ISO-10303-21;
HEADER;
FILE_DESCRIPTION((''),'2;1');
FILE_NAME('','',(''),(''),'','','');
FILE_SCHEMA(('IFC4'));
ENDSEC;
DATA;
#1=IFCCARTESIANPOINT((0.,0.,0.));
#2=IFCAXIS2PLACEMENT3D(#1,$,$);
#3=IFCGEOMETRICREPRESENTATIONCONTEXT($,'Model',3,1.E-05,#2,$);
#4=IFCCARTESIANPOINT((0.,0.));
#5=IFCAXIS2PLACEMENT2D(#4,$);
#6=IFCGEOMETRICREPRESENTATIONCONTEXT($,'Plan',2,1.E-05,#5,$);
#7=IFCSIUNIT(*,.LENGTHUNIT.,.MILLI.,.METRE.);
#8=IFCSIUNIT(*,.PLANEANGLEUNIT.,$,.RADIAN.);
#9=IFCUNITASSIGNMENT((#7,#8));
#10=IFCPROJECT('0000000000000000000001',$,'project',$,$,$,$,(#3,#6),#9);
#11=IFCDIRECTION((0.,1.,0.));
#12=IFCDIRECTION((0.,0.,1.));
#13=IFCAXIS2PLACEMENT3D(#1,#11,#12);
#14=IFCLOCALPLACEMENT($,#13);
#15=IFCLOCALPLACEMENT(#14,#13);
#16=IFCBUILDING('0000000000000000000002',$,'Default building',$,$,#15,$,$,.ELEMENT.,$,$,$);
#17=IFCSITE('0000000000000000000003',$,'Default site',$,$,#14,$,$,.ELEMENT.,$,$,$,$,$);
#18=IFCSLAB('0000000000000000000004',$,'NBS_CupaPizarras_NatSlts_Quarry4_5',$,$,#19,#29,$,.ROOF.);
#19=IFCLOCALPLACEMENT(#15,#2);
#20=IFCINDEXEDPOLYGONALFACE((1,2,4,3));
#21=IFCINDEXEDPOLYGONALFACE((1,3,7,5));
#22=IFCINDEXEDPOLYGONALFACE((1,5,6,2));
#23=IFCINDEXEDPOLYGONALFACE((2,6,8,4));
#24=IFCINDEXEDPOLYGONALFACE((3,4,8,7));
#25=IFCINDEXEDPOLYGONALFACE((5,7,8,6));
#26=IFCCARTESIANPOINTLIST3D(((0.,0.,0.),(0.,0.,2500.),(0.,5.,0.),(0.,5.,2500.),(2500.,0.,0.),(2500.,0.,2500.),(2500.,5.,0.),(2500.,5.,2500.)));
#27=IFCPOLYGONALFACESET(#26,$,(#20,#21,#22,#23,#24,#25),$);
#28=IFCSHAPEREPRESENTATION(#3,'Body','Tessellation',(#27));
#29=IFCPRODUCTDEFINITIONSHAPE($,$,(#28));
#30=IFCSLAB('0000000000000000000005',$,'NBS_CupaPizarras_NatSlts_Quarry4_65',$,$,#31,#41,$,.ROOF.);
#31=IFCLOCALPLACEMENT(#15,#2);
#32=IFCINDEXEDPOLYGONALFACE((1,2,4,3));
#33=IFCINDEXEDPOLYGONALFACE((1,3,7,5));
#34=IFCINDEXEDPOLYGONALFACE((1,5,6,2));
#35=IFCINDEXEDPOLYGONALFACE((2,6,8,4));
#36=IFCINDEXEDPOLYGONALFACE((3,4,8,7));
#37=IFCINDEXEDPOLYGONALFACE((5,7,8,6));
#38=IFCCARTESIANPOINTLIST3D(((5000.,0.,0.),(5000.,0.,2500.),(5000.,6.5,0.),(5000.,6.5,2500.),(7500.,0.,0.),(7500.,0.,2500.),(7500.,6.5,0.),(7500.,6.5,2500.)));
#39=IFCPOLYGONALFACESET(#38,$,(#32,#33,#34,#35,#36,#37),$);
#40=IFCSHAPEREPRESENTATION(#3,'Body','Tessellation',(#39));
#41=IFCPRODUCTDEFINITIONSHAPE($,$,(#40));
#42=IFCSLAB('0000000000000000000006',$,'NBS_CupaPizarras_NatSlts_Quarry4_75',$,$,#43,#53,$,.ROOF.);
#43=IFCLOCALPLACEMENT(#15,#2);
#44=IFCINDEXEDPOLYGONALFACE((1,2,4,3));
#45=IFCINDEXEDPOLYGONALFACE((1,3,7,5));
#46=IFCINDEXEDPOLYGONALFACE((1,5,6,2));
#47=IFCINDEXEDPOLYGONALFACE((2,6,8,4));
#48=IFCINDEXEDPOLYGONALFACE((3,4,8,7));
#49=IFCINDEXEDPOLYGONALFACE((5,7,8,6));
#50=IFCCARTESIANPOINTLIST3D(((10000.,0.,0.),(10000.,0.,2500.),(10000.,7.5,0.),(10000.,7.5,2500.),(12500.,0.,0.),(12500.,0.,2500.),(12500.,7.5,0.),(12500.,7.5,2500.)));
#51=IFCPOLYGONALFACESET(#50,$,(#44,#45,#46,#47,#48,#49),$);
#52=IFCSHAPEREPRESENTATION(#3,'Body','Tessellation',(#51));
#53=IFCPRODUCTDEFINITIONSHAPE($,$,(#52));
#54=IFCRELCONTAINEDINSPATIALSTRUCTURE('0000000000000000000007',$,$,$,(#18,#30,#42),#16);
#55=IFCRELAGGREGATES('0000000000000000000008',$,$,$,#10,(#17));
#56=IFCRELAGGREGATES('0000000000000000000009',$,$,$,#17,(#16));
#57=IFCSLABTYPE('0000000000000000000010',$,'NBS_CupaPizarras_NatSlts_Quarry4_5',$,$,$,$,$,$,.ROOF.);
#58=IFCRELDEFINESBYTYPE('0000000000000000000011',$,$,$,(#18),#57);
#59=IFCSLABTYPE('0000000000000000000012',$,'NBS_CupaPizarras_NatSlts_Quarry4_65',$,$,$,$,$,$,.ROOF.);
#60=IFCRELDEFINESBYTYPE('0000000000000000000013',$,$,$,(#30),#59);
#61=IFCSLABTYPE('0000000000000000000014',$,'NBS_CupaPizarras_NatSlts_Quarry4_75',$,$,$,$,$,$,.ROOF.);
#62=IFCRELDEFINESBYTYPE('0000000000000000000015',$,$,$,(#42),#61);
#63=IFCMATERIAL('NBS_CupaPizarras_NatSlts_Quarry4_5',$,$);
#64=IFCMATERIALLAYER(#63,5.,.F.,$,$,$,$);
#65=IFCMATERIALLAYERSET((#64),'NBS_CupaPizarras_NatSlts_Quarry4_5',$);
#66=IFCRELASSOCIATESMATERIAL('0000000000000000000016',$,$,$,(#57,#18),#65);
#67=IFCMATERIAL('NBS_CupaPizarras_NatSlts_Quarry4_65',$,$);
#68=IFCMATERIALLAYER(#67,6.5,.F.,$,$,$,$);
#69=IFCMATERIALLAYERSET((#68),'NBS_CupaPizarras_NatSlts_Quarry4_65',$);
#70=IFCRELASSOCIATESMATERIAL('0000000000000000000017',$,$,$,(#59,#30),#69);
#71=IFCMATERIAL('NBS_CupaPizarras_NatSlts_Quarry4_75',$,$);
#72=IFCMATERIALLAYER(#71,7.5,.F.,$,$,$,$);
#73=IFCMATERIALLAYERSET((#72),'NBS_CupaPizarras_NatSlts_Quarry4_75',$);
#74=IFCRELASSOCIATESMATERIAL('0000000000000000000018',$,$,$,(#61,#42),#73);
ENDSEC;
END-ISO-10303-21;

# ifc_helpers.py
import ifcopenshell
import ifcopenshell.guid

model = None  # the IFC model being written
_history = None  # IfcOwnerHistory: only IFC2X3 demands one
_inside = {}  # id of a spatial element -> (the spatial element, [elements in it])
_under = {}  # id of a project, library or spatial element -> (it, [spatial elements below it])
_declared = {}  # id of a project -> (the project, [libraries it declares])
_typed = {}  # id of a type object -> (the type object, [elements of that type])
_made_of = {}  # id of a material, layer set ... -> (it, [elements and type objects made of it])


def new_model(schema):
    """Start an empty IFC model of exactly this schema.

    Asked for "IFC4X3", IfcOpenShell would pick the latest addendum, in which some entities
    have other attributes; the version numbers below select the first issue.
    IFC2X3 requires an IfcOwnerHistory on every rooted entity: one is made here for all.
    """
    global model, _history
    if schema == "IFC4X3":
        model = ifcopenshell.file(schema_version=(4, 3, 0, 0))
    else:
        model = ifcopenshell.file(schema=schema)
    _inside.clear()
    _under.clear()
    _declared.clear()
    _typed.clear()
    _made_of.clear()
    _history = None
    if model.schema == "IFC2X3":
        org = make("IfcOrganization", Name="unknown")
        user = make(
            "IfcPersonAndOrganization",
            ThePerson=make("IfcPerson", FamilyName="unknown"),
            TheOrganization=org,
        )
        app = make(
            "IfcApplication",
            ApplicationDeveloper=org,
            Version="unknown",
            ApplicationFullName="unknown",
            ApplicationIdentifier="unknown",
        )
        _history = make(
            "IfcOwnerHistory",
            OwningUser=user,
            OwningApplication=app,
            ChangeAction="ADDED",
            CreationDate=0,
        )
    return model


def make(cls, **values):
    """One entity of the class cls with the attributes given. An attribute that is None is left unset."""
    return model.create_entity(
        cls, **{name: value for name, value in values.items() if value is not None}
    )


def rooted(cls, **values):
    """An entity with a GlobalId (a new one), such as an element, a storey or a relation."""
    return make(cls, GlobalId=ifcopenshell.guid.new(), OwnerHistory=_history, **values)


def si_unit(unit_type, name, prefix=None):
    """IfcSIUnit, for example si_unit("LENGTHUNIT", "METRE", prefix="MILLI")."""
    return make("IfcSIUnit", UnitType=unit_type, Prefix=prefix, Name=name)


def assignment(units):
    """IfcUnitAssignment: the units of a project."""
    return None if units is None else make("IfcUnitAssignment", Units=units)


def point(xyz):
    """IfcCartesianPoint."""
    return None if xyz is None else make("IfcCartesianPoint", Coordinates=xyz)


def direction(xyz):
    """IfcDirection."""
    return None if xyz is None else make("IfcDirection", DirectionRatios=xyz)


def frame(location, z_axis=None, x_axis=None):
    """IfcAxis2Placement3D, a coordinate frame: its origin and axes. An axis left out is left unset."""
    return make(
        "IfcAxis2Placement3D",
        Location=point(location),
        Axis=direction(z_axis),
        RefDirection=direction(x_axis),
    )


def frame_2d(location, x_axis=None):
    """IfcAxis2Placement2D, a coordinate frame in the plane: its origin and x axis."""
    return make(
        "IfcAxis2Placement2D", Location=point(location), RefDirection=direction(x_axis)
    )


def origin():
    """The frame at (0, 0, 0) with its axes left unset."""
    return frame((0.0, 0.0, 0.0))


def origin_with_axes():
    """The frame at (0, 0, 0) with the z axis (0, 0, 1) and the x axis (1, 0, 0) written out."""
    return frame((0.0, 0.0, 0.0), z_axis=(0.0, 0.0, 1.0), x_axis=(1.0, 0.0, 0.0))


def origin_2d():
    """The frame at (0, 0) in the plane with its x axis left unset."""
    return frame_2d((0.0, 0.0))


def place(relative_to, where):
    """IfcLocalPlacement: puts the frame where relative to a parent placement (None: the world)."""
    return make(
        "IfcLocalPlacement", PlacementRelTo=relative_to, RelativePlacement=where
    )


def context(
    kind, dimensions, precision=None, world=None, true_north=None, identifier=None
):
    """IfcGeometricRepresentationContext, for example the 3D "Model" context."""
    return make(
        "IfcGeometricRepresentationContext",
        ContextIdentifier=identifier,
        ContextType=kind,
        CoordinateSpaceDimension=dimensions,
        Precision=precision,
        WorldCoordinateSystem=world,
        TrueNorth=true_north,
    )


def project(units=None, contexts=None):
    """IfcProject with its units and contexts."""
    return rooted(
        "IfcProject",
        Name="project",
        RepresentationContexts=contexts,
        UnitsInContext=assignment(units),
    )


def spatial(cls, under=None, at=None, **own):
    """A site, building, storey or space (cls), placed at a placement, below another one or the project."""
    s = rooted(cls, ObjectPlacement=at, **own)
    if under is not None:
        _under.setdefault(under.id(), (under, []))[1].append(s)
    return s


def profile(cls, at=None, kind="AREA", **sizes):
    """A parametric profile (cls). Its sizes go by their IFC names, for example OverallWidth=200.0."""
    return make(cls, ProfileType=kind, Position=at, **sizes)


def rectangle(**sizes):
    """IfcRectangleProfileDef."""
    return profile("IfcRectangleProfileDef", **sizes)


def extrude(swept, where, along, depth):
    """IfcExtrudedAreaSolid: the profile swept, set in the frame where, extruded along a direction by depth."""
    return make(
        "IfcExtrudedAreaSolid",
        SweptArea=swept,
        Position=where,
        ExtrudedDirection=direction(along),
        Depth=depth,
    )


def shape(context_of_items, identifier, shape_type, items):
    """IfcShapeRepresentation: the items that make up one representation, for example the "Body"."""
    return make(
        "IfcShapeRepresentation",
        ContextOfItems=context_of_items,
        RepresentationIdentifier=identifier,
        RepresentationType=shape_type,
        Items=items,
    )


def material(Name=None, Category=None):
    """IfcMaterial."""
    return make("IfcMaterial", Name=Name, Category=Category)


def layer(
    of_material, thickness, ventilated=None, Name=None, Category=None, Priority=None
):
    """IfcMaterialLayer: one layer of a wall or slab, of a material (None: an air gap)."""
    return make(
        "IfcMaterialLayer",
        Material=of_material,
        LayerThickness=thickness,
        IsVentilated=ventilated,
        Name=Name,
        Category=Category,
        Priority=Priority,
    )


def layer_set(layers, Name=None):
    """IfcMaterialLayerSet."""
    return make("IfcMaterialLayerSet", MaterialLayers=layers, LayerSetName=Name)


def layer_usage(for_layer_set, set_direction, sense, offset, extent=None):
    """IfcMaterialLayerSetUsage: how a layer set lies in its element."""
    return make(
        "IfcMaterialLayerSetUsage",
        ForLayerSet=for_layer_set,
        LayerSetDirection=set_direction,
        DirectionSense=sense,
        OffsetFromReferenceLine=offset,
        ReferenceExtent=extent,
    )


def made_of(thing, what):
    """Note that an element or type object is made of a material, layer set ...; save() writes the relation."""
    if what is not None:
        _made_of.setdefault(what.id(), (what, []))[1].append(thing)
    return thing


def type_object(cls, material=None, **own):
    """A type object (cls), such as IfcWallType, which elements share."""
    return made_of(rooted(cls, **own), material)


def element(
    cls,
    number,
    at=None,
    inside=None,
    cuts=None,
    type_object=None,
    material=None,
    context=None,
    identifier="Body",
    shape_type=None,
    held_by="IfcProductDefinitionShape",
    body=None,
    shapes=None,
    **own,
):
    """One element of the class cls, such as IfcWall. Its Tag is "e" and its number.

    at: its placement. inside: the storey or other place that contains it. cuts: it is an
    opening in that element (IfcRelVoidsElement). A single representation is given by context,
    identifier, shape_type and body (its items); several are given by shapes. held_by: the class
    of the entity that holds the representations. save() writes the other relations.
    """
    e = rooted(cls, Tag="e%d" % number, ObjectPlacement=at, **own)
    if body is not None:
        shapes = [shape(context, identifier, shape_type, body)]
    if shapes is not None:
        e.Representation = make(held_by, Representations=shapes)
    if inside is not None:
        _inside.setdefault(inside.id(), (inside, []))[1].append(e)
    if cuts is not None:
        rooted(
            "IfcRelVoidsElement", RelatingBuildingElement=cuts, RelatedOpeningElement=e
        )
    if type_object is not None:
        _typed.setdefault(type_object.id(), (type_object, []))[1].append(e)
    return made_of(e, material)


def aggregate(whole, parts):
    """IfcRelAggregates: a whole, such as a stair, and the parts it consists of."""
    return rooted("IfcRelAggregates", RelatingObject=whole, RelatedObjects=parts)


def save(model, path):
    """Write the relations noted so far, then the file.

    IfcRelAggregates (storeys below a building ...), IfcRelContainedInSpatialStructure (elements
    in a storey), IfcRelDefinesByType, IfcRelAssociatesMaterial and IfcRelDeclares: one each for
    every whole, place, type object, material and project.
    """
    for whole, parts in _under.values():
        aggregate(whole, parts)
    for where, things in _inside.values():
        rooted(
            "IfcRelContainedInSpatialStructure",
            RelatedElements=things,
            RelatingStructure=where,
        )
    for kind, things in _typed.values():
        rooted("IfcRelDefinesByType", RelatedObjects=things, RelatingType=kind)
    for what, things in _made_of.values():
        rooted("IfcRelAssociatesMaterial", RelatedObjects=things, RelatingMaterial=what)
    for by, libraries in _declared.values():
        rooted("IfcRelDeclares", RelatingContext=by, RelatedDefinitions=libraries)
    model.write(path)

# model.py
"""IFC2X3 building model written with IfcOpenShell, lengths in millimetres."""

from ifc_helpers import new_model, si_unit, frame, frame_2d, origin, origin_with_axes, origin_2d, place, context, project, spatial, rectangle, extrude, material, layer, layer_set, layer_usage, type_object, element, save


model = new_model("IFC2X3")

# Units and contexts
model_context = context("Model", 3, precision=1e-05, world=origin())
plan_context = context("Plan", 2, precision=1e-05, world=origin_2d())
ifc_project = project(units=[si_unit("LENGTHUNIT", "METRE", prefix="MILLI"), si_unit("PLANEANGLEUNIT", "RADIAN")], contexts=[model_context, plan_context])

# Site, building
site_placement = place(None, frame((0.0, 0.0, 0.0), z_axis=(0.0, 1.0, 0.0), x_axis=(0.0, 0.0, 1.0)))
site = spatial("IfcSite", under=ifc_project, at=site_placement, Name="Default site", CompositionType="ELEMENT")
building_placement = place(site_placement, frame((0.0, 0.0, 0.0), z_axis=(0.0, 1.0, 0.0), x_axis=(0.0, 0.0, 1.0)))
building = spatial("IfcBuilding", under=site, at=building_placement, Name="Default building", CompositionType="ELEMENT")

# Slabs
ifc_material_1 = material(Name="NBS_CupaPizarras_NatSlts_Quarry4_5")
ifc_layer_1 = layer(ifc_material_1, 5.0, ventilated=False)
ifc_layer_set_1 = layer_set([ifc_layer_1], Name="NBS_CupaPizarras_NatSlts_Quarry4_5")
ifc_layer_usage_1 = layer_usage(ifc_layer_set_1, "AXIS3", "NEGATIVE", 0.0)
slab_type_1 = type_object("IfcSlabType", Name="NBS_CupaPizarras_NatSlts_Quarry4_5", PredefinedType="ROOF", material=ifc_layer_set_1)
slab_1_placement = place(None, origin())
element("IfcSlab", 1, at=slab_1_placement, inside=building, type_object=slab_type_1, material=ifc_layer_usage_1, Name="NBS_CupaPizarras_NatSlts_Quarry4_5", PredefinedType="ROOF", context=model_context, shape_type="SweptSolid", body=[
    extrude(rectangle(XDim=2500.0, YDim=2500.0, at=frame_2d((1250.0, 1250.0))), origin_with_axes(), (0.0, 0.0, 1.0), 5.0),
])
ifc_material_2 = material(Name="NBS_CupaPizarras_NatSlts_Quarry4_65")
ifc_layer_2 = layer(ifc_material_2, 6.5, ventilated=False)
ifc_layer_set_2 = layer_set([ifc_layer_2], Name="NBS_CupaPizarras_NatSlts_Quarry4_65")
ifc_layer_usage_2 = layer_usage(ifc_layer_set_2, "AXIS3", "NEGATIVE", 0.0)
slab_type_2 = type_object("IfcSlabType", Name="NBS_CupaPizarras_NatSlts_Quarry4_65", PredefinedType="ROOF", material=ifc_layer_set_2)
slab_2_placement = place(None, frame((0.0, 5000.0, 0.0)))
element("IfcSlab", 2, at=slab_2_placement, inside=building, type_object=slab_type_2, material=ifc_layer_usage_2, Name="NBS_CupaPizarras_NatSlts_Quarry4_65", PredefinedType="ROOF", context=model_context, shape_type="SweptSolid", body=[
    extrude(rectangle(XDim=2500.0, YDim=2500.0, at=frame_2d((1250.0, 1250.0))), origin_with_axes(), (0.0, 0.0, 1.0), 6.5),
])
ifc_material_3 = material(Name="NBS_CupaPizarras_NatSlts_Quarry4_75")
ifc_layer_3 = layer(ifc_material_3, 7.5, ventilated=False)
ifc_layer_set_3 = layer_set([ifc_layer_3], Name="NBS_CupaPizarras_NatSlts_Quarry4_75")
ifc_layer_usage_3 = layer_usage(ifc_layer_set_3, "AXIS3", "NEGATIVE", 0.0)
slab_type_3 = type_object("IfcSlabType", Name="NBS_CupaPizarras_NatSlts_Quarry4_75", PredefinedType="ROOF", material=ifc_layer_set_3)
slab_3_placement = place(None, frame((0.0, 10000.0, 0.0)))
element("IfcSlab", 3, at=slab_3_placement, inside=building, type_object=slab_type_3, material=ifc_layer_usage_3, Name="NBS_CupaPizarras_NatSlts_Quarry4_75", PredefinedType="ROOF", context=model_context, shape_type="SweptSolid", body=[
    extrude(rectangle(XDim=2500.0, YDim=2500.0, at=frame_2d((1250.0, 1250.0))), origin_with_axes(), (0.0, 0.0, 1.0), 7.5),
])

save(model, "model.ifc")
